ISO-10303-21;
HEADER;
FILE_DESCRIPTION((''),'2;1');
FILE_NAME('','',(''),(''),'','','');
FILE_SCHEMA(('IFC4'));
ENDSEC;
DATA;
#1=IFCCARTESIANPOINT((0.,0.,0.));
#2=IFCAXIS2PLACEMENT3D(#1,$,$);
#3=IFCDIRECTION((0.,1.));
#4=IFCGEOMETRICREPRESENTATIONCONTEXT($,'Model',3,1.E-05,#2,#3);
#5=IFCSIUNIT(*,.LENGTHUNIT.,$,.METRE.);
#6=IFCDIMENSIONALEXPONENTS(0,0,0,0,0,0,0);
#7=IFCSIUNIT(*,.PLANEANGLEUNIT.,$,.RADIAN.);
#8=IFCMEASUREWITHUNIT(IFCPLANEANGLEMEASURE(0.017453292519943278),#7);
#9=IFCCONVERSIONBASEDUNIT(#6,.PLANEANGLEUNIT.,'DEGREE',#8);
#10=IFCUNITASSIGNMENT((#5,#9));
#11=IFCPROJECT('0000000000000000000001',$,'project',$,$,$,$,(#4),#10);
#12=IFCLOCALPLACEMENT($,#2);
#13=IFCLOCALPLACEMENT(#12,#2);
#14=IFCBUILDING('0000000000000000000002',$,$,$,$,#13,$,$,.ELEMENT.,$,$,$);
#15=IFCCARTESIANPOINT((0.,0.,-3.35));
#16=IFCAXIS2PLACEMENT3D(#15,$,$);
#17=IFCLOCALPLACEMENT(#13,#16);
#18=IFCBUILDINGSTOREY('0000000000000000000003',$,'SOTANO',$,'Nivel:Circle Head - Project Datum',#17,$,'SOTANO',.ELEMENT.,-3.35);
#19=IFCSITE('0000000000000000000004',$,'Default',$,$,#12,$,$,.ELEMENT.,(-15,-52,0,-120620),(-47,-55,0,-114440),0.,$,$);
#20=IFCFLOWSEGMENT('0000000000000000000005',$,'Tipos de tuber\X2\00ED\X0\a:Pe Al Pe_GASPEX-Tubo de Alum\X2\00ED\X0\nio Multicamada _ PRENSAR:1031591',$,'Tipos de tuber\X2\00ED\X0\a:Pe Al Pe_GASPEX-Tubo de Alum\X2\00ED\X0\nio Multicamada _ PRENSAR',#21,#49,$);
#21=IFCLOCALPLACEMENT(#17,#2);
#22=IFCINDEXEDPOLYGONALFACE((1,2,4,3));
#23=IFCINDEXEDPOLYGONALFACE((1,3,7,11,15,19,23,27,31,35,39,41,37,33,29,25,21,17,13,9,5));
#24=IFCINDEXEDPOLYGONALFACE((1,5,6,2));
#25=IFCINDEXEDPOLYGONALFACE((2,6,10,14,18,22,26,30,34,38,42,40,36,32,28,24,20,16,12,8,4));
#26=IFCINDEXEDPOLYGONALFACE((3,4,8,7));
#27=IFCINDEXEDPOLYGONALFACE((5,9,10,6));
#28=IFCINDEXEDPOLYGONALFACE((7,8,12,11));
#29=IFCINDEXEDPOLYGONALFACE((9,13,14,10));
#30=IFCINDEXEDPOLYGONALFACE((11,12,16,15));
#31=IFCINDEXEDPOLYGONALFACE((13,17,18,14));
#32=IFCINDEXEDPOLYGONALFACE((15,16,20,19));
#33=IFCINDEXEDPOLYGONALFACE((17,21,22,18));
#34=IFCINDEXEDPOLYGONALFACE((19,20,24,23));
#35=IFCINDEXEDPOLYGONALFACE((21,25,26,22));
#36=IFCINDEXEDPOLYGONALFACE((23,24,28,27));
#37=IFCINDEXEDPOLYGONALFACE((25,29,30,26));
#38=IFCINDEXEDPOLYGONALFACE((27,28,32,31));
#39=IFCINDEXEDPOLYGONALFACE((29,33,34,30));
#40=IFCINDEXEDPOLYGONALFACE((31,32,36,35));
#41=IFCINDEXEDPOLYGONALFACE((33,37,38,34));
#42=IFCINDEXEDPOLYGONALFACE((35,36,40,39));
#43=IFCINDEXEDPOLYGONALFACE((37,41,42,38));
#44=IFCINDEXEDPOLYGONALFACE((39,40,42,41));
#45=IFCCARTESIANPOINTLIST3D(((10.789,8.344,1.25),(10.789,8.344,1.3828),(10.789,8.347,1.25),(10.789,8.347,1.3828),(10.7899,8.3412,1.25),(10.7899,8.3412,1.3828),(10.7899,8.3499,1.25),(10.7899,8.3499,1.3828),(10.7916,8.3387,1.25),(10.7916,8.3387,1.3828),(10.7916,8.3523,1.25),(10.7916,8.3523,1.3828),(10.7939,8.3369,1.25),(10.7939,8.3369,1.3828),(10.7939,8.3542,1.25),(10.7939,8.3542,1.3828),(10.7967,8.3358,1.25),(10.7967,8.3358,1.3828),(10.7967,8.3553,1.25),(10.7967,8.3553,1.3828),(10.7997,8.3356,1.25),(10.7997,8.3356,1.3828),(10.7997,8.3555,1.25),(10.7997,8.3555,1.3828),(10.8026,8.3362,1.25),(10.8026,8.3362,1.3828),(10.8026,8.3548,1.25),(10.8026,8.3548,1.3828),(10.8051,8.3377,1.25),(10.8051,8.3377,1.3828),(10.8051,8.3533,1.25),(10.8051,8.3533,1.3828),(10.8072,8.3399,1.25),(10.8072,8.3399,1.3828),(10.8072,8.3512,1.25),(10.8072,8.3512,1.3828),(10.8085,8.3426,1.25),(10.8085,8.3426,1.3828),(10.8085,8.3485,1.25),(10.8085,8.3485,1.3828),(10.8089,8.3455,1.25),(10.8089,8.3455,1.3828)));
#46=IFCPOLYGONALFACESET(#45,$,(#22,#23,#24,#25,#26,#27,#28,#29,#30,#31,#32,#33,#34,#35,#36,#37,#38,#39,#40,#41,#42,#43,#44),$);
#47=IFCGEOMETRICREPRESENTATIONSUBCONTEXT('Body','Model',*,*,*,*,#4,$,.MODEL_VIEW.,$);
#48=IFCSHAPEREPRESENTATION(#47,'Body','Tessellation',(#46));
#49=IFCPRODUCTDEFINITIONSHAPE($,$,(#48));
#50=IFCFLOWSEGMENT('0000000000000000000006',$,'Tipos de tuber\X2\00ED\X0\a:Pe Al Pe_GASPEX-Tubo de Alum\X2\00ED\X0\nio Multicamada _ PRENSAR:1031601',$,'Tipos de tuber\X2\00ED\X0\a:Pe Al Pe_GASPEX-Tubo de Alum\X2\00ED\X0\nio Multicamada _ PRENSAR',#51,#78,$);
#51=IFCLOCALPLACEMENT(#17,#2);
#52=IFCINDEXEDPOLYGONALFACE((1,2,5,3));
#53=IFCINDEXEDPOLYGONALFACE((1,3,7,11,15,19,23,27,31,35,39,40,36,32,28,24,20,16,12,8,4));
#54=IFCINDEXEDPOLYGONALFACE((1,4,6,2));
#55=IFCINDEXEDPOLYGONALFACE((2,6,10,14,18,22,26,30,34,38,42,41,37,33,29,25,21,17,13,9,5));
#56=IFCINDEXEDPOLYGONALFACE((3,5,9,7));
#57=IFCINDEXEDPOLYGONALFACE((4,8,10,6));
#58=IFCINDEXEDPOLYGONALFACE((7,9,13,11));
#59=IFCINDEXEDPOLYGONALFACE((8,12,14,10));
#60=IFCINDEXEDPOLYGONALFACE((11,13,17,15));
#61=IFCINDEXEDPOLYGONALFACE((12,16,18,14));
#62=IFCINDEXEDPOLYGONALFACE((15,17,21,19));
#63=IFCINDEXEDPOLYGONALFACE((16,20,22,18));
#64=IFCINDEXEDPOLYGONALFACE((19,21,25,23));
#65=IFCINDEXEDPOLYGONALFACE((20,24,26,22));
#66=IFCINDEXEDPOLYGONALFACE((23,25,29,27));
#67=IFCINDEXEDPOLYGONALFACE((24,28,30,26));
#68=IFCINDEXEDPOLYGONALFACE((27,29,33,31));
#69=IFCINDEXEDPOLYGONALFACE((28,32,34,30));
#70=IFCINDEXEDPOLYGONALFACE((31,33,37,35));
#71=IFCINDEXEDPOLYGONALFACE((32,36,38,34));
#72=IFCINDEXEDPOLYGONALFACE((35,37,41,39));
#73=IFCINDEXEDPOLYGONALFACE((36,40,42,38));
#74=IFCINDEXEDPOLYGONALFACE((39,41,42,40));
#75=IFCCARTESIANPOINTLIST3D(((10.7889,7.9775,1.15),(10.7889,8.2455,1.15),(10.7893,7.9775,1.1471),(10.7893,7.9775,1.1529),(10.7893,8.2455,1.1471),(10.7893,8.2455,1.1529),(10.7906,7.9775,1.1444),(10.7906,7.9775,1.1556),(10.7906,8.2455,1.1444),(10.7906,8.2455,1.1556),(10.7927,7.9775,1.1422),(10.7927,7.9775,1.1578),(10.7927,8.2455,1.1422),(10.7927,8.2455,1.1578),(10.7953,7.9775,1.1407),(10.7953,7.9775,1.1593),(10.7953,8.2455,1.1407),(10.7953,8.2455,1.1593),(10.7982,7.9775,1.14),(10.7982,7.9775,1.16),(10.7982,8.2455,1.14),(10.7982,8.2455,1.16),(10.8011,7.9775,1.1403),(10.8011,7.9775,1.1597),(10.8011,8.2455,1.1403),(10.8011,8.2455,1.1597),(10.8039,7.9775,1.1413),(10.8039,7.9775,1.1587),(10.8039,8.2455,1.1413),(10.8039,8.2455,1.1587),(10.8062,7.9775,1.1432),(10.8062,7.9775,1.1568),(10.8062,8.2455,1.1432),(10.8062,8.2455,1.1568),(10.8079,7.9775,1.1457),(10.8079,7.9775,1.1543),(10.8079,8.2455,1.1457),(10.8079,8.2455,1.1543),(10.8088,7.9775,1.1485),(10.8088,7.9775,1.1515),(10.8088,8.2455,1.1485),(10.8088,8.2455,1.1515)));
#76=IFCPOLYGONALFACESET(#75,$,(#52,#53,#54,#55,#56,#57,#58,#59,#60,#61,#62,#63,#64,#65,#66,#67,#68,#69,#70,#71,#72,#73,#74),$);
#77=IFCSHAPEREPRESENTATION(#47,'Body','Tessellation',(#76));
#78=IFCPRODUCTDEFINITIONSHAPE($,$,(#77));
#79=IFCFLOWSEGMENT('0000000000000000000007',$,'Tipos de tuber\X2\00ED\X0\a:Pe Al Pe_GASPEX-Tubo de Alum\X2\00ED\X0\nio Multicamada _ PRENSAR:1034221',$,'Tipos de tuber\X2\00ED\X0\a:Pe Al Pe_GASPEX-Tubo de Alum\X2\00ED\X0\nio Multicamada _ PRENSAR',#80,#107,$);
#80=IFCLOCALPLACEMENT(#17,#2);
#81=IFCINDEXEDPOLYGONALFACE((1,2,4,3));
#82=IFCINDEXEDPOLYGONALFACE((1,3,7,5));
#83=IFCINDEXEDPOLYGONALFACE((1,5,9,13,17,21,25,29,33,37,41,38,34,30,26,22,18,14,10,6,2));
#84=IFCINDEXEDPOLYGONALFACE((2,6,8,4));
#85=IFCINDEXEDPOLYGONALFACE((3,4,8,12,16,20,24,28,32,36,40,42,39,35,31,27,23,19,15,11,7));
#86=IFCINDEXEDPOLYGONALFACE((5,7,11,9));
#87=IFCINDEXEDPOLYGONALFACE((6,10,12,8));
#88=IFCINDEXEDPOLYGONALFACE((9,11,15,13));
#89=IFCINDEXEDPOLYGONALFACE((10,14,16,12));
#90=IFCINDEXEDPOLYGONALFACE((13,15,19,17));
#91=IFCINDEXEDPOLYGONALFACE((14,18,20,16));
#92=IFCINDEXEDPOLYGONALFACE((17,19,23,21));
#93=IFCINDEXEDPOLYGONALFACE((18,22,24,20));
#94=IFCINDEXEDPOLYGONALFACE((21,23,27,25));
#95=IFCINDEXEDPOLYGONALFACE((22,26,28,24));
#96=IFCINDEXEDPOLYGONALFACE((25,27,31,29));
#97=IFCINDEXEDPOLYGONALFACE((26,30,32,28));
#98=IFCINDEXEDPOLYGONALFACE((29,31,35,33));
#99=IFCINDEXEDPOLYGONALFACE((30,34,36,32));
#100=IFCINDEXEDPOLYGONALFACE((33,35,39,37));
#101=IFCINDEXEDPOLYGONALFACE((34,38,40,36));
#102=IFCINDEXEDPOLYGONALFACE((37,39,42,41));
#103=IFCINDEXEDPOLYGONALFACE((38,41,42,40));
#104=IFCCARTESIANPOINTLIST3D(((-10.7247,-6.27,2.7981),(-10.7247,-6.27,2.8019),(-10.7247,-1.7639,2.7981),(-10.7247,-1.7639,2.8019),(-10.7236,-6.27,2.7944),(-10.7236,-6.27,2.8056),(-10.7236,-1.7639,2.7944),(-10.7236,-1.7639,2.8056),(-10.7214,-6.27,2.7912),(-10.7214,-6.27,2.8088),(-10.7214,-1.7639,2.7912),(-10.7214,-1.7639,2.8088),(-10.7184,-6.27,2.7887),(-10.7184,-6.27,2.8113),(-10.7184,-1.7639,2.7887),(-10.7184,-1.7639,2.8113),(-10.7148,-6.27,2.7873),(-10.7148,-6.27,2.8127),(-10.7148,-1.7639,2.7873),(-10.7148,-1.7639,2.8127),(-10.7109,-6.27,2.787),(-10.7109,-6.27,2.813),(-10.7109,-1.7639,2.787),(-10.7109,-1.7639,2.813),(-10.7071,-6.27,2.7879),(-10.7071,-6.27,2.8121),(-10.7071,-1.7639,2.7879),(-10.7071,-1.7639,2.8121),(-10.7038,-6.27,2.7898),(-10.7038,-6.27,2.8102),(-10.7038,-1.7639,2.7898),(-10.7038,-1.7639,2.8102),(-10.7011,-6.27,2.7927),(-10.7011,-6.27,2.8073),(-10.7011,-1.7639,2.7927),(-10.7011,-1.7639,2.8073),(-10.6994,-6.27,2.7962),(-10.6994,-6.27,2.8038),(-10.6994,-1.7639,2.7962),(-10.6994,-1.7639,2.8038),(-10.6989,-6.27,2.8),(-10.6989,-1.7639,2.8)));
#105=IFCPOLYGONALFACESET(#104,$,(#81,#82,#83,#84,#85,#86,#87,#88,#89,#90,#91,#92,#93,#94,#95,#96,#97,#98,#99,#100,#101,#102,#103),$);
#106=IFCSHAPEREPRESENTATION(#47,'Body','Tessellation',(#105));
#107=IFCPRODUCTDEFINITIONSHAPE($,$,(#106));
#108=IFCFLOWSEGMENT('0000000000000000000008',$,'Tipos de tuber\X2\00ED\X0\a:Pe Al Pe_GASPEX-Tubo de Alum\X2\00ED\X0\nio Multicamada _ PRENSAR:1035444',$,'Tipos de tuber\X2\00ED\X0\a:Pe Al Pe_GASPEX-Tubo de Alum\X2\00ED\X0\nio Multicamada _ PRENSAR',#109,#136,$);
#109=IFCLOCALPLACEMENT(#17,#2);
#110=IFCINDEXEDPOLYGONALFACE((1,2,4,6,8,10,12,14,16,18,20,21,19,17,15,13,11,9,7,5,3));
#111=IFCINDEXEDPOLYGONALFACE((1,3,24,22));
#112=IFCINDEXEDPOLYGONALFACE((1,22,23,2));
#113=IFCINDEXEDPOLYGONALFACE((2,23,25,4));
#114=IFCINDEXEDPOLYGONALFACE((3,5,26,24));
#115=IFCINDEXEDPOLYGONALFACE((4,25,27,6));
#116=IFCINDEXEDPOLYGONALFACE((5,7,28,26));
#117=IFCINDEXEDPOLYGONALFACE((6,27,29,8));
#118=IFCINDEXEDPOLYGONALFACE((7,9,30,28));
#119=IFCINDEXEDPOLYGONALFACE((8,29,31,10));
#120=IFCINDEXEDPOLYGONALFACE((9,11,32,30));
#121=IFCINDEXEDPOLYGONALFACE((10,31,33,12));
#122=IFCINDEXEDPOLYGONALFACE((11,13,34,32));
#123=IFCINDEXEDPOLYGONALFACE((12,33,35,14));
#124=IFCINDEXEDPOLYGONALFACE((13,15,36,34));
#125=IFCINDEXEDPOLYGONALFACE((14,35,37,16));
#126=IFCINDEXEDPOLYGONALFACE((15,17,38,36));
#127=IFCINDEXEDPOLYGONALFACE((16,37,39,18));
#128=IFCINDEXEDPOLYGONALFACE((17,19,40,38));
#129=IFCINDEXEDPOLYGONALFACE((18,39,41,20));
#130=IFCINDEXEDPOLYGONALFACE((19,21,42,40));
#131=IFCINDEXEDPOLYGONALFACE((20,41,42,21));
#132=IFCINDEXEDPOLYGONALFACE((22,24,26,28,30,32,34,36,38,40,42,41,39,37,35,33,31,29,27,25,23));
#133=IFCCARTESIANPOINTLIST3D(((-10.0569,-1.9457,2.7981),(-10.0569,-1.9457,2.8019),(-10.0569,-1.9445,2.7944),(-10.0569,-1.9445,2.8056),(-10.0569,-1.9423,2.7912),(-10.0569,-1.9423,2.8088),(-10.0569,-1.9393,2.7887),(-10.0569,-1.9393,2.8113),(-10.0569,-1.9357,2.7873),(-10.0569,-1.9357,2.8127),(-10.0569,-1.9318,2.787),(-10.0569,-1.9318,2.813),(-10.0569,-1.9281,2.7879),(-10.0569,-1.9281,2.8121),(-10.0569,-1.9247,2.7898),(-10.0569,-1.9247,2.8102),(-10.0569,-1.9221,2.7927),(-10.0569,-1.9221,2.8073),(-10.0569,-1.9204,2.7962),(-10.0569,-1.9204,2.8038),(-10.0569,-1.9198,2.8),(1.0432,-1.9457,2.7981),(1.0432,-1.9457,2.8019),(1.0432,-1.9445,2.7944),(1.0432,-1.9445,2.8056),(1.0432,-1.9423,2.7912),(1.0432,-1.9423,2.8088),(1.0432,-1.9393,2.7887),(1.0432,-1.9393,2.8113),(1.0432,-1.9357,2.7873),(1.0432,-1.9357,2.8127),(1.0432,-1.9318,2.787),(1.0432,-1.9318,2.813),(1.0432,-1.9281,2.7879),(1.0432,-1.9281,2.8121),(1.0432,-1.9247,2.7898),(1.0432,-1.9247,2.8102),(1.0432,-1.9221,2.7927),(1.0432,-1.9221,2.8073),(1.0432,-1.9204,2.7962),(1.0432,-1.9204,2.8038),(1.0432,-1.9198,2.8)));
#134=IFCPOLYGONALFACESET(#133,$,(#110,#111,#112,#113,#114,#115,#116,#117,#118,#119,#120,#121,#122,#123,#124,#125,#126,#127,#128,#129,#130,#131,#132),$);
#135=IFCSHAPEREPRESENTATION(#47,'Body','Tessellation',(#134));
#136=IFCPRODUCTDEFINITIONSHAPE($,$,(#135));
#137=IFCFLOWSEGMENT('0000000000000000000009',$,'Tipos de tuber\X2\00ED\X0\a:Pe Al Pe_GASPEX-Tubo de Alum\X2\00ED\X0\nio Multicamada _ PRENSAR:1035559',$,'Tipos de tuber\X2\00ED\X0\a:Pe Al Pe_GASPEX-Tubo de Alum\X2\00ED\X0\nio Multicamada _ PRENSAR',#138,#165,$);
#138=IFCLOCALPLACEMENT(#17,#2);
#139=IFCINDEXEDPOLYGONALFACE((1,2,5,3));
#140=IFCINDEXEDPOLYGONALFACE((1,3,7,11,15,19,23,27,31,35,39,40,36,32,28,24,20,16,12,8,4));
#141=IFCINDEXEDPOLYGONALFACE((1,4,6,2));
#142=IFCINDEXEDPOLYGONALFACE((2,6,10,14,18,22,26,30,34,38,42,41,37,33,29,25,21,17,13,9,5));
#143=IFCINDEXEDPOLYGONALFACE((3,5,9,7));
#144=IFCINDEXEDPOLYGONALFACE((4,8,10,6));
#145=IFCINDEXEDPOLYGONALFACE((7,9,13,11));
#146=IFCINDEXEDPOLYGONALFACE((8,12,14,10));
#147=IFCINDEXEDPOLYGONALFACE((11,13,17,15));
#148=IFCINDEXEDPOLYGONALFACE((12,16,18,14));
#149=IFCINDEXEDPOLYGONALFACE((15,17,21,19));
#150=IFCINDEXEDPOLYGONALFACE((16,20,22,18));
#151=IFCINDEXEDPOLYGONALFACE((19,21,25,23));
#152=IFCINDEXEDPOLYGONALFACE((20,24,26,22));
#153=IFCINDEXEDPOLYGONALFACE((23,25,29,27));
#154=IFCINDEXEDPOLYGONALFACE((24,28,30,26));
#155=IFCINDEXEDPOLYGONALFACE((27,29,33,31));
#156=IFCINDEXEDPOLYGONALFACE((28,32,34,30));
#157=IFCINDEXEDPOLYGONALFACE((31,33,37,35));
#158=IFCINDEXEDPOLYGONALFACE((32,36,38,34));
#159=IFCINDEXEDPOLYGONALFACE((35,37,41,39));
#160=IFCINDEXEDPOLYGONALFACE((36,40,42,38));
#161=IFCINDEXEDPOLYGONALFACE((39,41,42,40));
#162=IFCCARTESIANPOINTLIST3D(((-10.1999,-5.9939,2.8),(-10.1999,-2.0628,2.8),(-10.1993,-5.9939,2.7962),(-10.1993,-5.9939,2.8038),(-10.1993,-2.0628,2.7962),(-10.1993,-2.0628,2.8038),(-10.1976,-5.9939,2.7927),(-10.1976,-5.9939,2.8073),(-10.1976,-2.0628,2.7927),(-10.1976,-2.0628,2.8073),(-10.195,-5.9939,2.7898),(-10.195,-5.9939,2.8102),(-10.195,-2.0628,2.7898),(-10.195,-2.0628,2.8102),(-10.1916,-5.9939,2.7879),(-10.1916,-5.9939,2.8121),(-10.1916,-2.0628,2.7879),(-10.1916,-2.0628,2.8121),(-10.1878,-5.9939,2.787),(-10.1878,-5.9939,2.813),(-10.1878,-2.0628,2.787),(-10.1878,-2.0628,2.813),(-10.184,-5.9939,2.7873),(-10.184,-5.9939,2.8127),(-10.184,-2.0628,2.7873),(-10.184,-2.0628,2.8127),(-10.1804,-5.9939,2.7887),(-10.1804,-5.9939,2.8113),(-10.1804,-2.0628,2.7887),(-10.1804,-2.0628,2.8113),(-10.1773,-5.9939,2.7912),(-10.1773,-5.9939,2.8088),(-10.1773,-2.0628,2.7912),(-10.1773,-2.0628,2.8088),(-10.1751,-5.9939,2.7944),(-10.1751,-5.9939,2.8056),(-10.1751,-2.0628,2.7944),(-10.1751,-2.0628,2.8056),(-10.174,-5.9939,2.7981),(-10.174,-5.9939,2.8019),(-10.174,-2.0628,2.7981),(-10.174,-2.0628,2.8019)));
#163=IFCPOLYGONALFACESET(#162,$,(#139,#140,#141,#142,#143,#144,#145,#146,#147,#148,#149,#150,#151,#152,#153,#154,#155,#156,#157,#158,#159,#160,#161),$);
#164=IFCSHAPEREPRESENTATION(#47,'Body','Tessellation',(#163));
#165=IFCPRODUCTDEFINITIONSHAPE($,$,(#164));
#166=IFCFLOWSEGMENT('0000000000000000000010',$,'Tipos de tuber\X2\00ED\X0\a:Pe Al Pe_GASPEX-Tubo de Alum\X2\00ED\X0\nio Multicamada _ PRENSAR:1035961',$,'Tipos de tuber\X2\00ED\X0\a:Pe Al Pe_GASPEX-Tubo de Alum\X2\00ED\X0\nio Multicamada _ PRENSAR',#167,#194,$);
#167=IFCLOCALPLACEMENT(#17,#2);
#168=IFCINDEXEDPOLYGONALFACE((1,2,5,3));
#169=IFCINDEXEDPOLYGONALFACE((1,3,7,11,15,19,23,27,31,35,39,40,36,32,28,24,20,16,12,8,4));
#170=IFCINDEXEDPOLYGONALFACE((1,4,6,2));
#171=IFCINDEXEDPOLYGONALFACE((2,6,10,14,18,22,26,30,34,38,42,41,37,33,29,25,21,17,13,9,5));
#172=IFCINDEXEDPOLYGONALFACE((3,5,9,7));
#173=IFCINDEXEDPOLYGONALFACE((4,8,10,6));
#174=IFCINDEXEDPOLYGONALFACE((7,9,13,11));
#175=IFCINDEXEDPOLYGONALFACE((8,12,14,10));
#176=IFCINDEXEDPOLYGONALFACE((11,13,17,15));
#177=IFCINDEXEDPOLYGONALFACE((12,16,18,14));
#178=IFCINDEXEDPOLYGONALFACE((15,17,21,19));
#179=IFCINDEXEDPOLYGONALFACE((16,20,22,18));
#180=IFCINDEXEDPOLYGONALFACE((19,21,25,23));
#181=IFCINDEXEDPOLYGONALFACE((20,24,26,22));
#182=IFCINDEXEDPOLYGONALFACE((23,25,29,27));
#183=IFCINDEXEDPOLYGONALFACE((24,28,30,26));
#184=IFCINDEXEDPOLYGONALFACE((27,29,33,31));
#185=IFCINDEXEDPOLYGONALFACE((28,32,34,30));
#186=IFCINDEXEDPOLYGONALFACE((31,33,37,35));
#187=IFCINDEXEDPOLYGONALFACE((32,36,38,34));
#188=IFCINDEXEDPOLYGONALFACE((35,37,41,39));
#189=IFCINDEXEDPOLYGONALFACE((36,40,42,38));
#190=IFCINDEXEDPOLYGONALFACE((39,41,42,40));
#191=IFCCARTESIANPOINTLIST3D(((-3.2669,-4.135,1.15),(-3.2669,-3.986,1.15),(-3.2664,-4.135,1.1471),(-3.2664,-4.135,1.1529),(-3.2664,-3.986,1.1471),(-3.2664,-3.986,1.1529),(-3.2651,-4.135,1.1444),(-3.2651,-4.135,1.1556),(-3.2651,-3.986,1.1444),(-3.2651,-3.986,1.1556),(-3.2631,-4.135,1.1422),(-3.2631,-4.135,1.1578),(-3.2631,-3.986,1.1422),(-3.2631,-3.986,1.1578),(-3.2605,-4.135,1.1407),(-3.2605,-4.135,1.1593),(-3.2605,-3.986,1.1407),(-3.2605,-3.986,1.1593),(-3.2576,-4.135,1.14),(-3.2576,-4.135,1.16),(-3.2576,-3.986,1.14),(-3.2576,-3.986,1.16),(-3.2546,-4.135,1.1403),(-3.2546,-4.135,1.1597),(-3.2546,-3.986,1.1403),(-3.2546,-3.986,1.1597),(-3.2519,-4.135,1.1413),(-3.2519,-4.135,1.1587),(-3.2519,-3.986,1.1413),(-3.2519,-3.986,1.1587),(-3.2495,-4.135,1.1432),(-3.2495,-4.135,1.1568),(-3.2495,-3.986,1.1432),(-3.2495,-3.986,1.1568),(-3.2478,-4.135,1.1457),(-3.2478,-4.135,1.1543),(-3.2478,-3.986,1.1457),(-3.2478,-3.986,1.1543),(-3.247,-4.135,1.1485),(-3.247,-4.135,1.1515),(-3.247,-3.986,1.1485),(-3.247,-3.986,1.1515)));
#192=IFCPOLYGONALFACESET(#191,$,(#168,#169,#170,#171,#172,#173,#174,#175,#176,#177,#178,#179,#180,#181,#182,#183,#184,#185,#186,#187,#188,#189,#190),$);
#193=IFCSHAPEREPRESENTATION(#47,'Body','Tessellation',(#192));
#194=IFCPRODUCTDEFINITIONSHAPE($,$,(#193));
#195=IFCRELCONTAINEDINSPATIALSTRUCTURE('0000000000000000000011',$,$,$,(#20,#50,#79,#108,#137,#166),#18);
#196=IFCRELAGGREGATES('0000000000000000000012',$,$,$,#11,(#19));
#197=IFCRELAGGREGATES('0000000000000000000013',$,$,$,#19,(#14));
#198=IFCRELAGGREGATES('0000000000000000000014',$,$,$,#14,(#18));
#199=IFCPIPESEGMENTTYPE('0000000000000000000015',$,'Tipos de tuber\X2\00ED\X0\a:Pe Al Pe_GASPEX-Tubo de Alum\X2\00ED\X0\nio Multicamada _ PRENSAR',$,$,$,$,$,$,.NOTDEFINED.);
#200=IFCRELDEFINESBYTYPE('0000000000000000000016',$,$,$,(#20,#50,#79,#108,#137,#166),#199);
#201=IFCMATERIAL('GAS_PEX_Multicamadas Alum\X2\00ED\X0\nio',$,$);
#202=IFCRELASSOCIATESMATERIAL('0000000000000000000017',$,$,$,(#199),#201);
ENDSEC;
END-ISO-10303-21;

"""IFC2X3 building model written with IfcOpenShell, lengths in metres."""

from ifc_helpers import new_model, entity, si_unit, converted_unit, direction, frame, frame_2d, origin, origin_2d_with_axis, place, context, subcontext, project, spatial, circle, extrude, material, type_object, element, save


model = new_model("IFC2X3")

# Units and contexts
model_context = context("Model", 3, precision=1e-05, world=origin(), true_north=direction((0.0, 1.0)))
body_context = subcontext(model_context, "Body", "Model", "MODEL_VIEW")
ifc_project = project(units=[si_unit("LENGTHUNIT", "METRE"), converted_unit("PLANEANGLEUNIT", "DEGREE", entity("IfcPlaneAngleMeasure", 0.017453292519943278), si_unit("PLANEANGLEUNIT", "RADIAN"), dimensions=[0, 0, 0, 0, 0, 0, 0])], contexts=[model_context])

# Site, building, storey
site_placement = place(None, origin())
site = spatial("IfcSite", under=ifc_project, at=site_placement, Name="Default", CompositionType="ELEMENT", RefLatitude=(-15, -52, 0, -120620), RefLongitude=(-47, -55, 0, -114440), RefElevation=0.0)
building_placement = place(site_placement, origin())
building = spatial("IfcBuilding", under=site, at=building_placement, CompositionType="ELEMENT")
storey_placement = place(building_placement, frame((0.0, 0.0, -3.35)))
storey = spatial("IfcBuildingStorey", under=building, at=storey_placement, Name="SOTANO", ObjectType="Nivel:Circle Head - Project Datum", LongName="SOTANO", CompositionType="ELEMENT", Elevation=-3.35)

# Flow segments
ifc_material = material(Name="GAS_PEX_Multicamadas Alumínio")
pipe_segment_type_1 = type_object("IfcPipeSegmentType", Name="Tipos de tubería:Pe Al Pe_GASPEX-Tubo de Alumínio Multicamada _ PRENSAR", PredefinedType="NOTDEFINED", material=ifc_material)
flow_segment_1_placement = place(storey_placement, origin())
element("IfcFlowSegment", 1, at=flow_segment_1_placement, inside=storey, type_object=pipe_segment_type_1, Name="Tipos de tubería:Pe Al Pe_GASPEX-Tubo de Alumínio Multicamada _ PRENSAR:1031591", ObjectType="Tipos de tubería:Pe Al Pe_GASPEX-Tubo de Alumínio Multicamada _ PRENSAR", context=body_context, shape_type="SweptSolid", body=[
    extrude(circle(Radius=0.01, at=origin_2d_with_axis()), frame((10.7989, 8.3455, 1.25)), (0.0, 0.0, 1.0), 0.1328),
])
flow_segment_2_placement = place(storey_placement, origin())
element("IfcFlowSegment", 2, at=flow_segment_2_placement, inside=storey, type_object=pipe_segment_type_1, Name="Tipos de tubería:Pe Al Pe_GASPEX-Tubo de Alumínio Multicamada _ PRENSAR:1031601", ObjectType="Tipos de tubería:Pe Al Pe_GASPEX-Tubo de Alumínio Multicamada _ PRENSAR", context=body_context, shape_type="SweptSolid", body=[
    extrude(circle(Radius=0.01, at=frame_2d((0.0, 0.0), x_axis=(1.0, 0.0))), frame((10.7989, 7.9775, 1.15), z_axis=(0.0, 1.0, 0.0), x_axis=(-1.0, 0.0, 0.0)), (0.0, 0.0, 1.0), 0.2681),
])
flow_segment_3_placement = place(storey_placement, origin())
element("IfcFlowSegment", 3, at=flow_segment_3_placement, inside=storey, type_object=pipe_segment_type_1, Name="Tipos de tubería:Pe Al Pe_GASPEX-Tubo de Alumínio Multicamada _ PRENSAR:1034221", ObjectType="Tipos de tubería:Pe Al Pe_GASPEX-Tubo de Alumínio Multicamada _ PRENSAR", context=body_context, shape_type="SweptSolid", body=[
    extrude(circle(Radius=0.013, at=origin_2d_with_axis()), frame((-10.7119, -6.27, 2.8), z_axis=(0.0, 1.0, 0.0), x_axis=(1.0, 0.0, 0.0)), (0.0, 0.0, 1.0), 4.5061),
])
flow_segment_4_placement = place(storey_placement, origin())
element("IfcFlowSegment", 4, at=flow_segment_4_placement, inside=storey, type_object=pipe_segment_type_1, Name="Tipos de tubería:Pe Al Pe_GASPEX-Tubo de Alumínio Multicamada _ PRENSAR:1035444", ObjectType="Tipos de tubería:Pe Al Pe_GASPEX-Tubo de Alumínio Multicamada _ PRENSAR", context=body_context, shape_type="SweptSolid", body=[
    extrude(circle(Radius=0.013, at=origin_2d_with_axis()), frame((-10.0569, -1.9328, 2.8), z_axis=(1.0, 0.0, 0.0), x_axis=(0.0, 1.0, 0.0)), (0.0, 0.0, 1.0), 11.1001),
])
flow_segment_5_placement = place(storey_placement, origin())
element("IfcFlowSegment", 5, at=flow_segment_5_placement, inside=storey, type_object=pipe_segment_type_1, Name="Tipos de tubería:Pe Al Pe_GASPEX-Tubo de Alumínio Multicamada _ PRENSAR:1035559", ObjectType="Tipos de tubería:Pe Al Pe_GASPEX-Tubo de Alumínio Multicamada _ PRENSAR", context=body_context, shape_type="SweptSolid", body=[
    extrude(circle(Radius=0.013, at=frame_2d((0.0, 0.0), x_axis=(1.0, 0.0))), frame((-10.1869, -5.9939, 2.8), z_axis=(0.0, 1.0, 0.0), x_axis=(-1.0, 0.0, 0.0)), (0.0, 0.0, 1.0), 3.9311),
])
flow_segment_6_placement = place(storey_placement, origin())
element("IfcFlowSegment", 6, at=flow_segment_6_placement, inside=storey, type_object=pipe_segment_type_1, Name="Tipos de tubería:Pe Al Pe_GASPEX-Tubo de Alumínio Multicamada _ PRENSAR:1035961", ObjectType="Tipos de tubería:Pe Al Pe_GASPEX-Tubo de Alumínio Multicamada _ PRENSAR", context=body_context, shape_type="SweptSolid", body=[
    extrude(circle(Radius=0.01, at=origin_2d_with_axis()), frame((-3.2569, -4.135, 1.15), z_axis=(0.0, 1.0, 0.0), x_axis=(-1.0, 0.0, 0.0)), (0.0, 0.0, 1.0), 0.149),
])

save(model, "model.ifc")
